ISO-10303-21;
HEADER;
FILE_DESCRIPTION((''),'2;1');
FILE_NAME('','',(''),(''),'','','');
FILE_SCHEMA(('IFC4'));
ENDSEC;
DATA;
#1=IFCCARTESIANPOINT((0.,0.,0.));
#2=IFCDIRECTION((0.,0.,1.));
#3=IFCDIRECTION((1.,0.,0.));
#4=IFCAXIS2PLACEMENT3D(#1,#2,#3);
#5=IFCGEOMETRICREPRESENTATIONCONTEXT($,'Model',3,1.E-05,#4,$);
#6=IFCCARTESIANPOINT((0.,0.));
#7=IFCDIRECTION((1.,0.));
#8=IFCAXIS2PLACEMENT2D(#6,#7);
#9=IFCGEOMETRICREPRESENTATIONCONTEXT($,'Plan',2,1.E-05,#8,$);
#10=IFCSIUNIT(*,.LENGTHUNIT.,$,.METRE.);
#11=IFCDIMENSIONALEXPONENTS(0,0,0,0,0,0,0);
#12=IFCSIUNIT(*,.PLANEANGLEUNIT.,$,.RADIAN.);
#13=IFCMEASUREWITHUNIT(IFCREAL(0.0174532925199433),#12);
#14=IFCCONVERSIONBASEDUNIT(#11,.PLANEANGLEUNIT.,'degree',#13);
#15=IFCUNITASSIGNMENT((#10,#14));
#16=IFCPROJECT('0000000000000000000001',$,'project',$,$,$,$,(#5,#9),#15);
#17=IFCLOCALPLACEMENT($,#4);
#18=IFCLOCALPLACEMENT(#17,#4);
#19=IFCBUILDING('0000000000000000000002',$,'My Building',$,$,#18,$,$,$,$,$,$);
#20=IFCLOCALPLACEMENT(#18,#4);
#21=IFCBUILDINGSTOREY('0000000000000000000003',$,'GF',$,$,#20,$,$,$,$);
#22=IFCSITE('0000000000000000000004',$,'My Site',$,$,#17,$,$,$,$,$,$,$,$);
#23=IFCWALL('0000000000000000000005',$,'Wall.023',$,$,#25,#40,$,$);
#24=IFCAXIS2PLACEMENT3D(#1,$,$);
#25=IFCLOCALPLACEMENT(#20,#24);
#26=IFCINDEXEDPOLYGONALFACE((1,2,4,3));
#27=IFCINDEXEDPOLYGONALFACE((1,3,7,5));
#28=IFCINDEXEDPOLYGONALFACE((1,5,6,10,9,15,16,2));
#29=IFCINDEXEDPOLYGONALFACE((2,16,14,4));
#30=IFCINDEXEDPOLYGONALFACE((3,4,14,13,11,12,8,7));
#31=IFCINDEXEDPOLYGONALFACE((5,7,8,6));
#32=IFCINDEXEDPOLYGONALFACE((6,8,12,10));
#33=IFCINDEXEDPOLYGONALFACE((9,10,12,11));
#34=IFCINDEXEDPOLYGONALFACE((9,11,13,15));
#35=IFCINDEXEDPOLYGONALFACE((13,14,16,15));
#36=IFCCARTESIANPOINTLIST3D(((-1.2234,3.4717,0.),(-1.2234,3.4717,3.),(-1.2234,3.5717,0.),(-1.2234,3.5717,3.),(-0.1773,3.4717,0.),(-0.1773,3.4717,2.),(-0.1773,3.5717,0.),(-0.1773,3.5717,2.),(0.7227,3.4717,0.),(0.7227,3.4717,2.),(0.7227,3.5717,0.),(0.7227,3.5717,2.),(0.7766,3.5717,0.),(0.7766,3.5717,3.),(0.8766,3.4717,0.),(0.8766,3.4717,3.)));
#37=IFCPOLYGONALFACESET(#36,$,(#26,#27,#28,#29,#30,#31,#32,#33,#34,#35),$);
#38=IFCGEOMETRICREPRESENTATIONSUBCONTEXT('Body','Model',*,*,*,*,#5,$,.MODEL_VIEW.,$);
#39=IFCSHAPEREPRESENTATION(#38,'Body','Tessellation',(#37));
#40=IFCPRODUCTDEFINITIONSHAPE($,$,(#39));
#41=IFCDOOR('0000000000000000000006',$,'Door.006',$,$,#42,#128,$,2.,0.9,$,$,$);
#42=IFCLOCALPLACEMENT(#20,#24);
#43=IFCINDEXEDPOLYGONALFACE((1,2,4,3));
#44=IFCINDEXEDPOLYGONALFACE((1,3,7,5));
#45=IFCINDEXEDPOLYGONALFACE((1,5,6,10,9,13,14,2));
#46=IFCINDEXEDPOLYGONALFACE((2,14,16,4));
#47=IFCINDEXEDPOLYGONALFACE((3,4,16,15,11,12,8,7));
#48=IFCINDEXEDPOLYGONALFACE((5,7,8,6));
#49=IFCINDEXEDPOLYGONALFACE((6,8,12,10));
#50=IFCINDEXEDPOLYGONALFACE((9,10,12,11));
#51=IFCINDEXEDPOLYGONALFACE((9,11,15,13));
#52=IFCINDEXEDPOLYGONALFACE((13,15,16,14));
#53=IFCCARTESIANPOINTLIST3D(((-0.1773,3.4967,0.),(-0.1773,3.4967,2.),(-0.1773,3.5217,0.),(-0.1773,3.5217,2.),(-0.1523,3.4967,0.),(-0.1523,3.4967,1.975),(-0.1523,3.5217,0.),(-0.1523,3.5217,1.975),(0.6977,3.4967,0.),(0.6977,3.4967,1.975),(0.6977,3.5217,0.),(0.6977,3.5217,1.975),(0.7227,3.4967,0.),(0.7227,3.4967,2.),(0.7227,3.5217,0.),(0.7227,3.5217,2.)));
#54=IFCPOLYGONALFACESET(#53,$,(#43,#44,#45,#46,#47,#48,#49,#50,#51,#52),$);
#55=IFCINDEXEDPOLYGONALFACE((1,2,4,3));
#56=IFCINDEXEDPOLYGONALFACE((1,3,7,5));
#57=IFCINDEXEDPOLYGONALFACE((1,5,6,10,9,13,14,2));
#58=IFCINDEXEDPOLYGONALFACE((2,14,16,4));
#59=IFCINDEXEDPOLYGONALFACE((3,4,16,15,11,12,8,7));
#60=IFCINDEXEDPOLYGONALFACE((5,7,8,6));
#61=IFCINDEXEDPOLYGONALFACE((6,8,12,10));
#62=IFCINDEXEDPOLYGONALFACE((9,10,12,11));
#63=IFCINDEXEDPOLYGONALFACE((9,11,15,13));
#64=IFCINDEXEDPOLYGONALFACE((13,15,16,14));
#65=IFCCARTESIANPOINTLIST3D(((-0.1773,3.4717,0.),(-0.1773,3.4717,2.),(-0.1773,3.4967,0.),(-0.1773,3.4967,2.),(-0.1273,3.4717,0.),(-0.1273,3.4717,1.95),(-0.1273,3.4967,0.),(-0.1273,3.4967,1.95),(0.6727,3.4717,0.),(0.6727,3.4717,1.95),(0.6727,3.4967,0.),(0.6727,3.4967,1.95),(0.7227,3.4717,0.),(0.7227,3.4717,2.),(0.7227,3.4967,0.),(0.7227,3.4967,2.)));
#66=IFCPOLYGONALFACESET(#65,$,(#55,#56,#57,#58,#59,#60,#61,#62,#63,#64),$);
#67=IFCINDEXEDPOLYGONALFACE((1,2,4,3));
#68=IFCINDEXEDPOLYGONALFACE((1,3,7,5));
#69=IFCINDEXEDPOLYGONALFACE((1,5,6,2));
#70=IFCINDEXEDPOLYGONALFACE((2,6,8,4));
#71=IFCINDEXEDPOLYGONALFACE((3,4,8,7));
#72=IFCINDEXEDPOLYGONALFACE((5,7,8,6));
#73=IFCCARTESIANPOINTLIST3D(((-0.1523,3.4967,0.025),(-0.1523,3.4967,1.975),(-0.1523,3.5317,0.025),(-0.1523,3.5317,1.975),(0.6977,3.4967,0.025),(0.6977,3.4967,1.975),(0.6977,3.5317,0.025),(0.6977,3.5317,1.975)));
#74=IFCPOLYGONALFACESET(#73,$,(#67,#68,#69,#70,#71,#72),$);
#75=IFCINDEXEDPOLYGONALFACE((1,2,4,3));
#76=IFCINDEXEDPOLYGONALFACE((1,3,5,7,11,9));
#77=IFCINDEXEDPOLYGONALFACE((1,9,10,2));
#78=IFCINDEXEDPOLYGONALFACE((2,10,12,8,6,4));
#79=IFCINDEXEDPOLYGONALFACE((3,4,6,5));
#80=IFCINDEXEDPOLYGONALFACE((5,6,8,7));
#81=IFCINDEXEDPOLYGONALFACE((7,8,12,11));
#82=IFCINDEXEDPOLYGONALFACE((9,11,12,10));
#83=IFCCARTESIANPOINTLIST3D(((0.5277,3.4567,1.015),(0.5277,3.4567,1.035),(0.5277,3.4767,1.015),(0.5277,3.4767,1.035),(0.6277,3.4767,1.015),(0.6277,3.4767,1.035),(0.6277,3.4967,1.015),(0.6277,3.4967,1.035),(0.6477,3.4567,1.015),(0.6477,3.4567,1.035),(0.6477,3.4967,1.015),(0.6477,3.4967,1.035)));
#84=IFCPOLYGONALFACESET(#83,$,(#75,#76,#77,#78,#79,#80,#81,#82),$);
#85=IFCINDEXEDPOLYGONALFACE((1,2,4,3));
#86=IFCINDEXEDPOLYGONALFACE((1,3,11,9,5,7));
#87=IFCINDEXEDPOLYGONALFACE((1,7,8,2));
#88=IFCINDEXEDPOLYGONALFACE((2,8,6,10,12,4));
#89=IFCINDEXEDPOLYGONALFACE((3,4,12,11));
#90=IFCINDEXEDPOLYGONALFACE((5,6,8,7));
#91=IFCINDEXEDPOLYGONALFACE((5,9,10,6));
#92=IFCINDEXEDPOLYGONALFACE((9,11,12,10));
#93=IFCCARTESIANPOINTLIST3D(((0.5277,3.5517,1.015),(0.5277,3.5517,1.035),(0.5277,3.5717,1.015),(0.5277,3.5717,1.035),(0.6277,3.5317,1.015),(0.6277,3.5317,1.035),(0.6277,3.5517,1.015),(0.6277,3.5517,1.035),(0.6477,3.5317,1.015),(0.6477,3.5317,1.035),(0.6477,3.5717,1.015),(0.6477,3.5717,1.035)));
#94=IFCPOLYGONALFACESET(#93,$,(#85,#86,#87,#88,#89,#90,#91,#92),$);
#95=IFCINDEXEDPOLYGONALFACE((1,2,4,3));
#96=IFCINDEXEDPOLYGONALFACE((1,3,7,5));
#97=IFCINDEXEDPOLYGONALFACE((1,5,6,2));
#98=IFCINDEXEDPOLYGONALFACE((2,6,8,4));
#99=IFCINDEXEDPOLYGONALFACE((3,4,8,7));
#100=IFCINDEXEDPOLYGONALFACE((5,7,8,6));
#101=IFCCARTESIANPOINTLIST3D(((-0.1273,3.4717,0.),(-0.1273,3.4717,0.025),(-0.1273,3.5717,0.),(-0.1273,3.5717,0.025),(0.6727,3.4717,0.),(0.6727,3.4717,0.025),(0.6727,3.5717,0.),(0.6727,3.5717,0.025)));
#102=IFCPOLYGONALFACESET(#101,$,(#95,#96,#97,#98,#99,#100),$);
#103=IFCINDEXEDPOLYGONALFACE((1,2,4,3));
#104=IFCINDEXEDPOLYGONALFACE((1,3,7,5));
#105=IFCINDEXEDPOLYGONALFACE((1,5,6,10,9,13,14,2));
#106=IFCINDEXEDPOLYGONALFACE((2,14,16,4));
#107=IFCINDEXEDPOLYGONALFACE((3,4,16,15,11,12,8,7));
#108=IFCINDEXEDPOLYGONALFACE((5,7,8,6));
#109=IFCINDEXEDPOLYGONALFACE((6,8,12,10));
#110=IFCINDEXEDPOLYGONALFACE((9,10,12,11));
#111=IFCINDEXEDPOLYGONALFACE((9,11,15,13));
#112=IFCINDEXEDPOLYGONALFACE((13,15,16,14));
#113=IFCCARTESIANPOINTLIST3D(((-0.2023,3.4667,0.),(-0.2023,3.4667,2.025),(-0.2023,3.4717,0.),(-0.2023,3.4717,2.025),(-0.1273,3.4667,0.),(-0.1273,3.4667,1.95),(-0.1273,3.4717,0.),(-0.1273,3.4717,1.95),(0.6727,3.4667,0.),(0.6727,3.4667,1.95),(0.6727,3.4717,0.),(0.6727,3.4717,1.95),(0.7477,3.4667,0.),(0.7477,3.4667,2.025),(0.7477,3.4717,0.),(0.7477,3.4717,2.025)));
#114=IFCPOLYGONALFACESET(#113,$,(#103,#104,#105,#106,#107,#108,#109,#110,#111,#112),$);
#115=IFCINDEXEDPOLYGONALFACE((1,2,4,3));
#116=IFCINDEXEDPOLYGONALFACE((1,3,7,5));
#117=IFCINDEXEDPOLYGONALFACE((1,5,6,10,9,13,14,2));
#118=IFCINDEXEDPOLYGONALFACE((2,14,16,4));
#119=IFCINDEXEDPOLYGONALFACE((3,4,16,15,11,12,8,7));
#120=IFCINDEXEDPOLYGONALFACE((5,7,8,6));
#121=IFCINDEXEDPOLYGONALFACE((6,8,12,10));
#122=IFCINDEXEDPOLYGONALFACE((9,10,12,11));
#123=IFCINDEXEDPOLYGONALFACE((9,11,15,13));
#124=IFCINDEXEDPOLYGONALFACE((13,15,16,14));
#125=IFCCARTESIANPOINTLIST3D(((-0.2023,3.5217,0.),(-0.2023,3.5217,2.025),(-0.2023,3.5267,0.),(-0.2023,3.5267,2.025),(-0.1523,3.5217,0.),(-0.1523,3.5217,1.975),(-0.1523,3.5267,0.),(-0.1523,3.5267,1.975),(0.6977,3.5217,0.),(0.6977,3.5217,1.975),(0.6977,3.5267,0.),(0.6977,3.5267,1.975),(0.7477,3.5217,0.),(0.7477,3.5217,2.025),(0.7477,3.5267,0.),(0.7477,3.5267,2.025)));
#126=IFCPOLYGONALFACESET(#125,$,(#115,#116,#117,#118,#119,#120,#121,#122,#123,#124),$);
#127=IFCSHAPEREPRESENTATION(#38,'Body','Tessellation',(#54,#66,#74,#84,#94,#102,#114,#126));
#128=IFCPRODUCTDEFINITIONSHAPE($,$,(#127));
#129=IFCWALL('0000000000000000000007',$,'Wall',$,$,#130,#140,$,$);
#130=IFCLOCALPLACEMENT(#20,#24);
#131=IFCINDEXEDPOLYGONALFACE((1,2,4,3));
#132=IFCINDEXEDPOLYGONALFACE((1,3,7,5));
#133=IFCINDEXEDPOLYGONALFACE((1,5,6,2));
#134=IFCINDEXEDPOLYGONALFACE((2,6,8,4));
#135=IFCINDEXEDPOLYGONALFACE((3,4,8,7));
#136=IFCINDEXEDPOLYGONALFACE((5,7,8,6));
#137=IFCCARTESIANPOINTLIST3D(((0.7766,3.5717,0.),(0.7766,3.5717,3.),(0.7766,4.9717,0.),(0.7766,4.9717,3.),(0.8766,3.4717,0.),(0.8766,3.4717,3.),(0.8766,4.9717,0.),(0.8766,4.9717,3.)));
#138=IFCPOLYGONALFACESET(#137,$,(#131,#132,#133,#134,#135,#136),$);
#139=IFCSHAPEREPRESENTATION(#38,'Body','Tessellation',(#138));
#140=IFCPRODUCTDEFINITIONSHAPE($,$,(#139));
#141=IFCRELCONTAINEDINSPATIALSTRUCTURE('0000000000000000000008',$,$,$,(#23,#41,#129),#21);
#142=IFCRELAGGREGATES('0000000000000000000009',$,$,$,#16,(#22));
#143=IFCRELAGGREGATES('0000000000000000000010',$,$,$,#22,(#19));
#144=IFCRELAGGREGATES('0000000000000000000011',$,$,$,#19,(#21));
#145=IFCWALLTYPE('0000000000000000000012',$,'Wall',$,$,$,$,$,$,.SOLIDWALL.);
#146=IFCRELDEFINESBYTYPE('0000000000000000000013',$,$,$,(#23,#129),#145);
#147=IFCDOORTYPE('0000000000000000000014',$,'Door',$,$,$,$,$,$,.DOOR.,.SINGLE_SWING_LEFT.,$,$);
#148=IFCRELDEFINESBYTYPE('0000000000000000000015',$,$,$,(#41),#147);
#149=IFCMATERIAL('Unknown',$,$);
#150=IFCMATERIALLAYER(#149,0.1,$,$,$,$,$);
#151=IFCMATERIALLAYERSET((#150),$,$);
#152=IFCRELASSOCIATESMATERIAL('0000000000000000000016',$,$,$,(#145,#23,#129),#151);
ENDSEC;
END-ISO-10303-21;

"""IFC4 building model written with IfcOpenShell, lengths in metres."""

from ifc_helpers import new_model, entity, si_unit, converted_unit, frame, origin_with_axes, origin_2d_with_axis, place, context, subcontext, project, spatial, line, indexed_curve, outline, extrude, shape, source, transform, mapped, material, layer, layer_set, layer_usage, type_object, type_shapes, element, fill, save


model = new_model("IFC4")

# Units and contexts
model_context = context("Model", 3, precision=1e-05, world=origin_with_axes())
plan_context = context("Plan", 2, precision=1e-05, world=origin_2d_with_axis())
body_context_1 = subcontext(model_context, "Body", "Model", "MODEL_VIEW")
body_context_2 = subcontext(plan_context, "Body", "Plan", "PLAN_VIEW")
ifc_project = project(units=[si_unit("LENGTHUNIT", "METRE"), converted_unit("PLANEANGLEUNIT", "degree", entity("IfcReal", 0.0174532925199433), si_unit("PLANEANGLEUNIT", "RADIAN"), dimensions=[0, 0, 0, 0, 0, 0, 0])], contexts=[model_context, plan_context])

# Site, building, storey
site_placement = place(None, origin_with_axes())
site = spatial("IfcSite", under=ifc_project, at=site_placement, Name="My Site")
building_placement = place(site_placement, origin_with_axes())
building = spatial("IfcBuilding", under=site, at=building_placement, Name="My Building")
storey_placement = place(building_placement, origin_with_axes())
storey = spatial("IfcBuildingStorey", under=building, at=storey_placement, Name="GF")

# Shared definitions
ifc_material = material(Name="Unknown")

# Shared definitions
ifc_layer_1 = layer(ifc_material, 0.1)
ifc_layer_set_1 = layer_set([ifc_layer_1])
wall_type = type_object("IfcWallType", Name="Wall", PredefinedType="SOLIDWALL", material=ifc_layer_set_1)

# Shared definitions
shared_shape_1 = source(origin_with_axes(), body_context_1, "Body", "SweptSolid", [
    extrude(outline(indexed_curve([(0.0, 0.0), (0.9, 0.0), (0.9, 2.0), (0.0, 2.0)], segments=[line(1, 2, 3, 4, 1)])), frame((0.0, -0.6, 0.0), z_axis=(0.0, -1.0, 0.0), x_axis=(1.0, 0.0, 0.0)), (0.0, 0.0, -1.0), 1.2),
])
door_type = type_object("IfcDoorType", Name="Door", OperationType="SINGLE_SWING_LEFT", PredefinedType="DOOR")
shared_shape_2 = source(origin_with_axes(), body_context_1, "Body", "SweptSolid", [
    extrude(outline(indexed_curve([(0.0, 0.0), (0.0, 2.0), (0.9, 2.0), (0.9, 0.0), (0.875, 0.0), (0.875, 1.975), (0.025, 1.975), (0.025, 0.0)], segments=[line(1, 2, 3, 4, 5, 6, 7, 8, 1)])), frame((0.0, 0.025, 0.0), z_axis=(0.0, -1.0, 0.0), x_axis=(1.0, 0.0, 0.0)), (0.0, 0.0, -1.0), 0.025),
    extrude(outline(indexed_curve([(0.0, 0.0), (0.0, 2.0), (0.9, 2.0), (0.9, 0.0), (0.85, 0.0), (0.85, 1.95), (0.05, 1.95), (0.05, 0.0)], segments=[line(1, 2, 3, 4, 5, 6, 7, 8, 1)])), frame((0.0, 0.0, 0.0), z_axis=(0.0, -1.0, 0.0), x_axis=(1.0, 0.0, 0.0)), (0.0, 0.0, -1.0), 0.025),
    extrude(outline(indexed_curve([(0.0, 0.0), (0.85, 0.0), (0.85, 0.035), (0.0, 0.035)], segments=[line(1, 2, 3, 4, 1)])), frame((0.025, 0.025, 0.025), z_axis=(0.0, 0.0, 1.0), x_axis=(1.0, 0.0, 0.0)), (0.0, 0.0, 1.0), 1.95),
    extrude(outline(indexed_curve([(0.0, 0.0), (0.0, -0.04), (-0.12, -0.04), (-0.12, -0.02), (-0.02, -0.02), (-0.02, 0.0)], segments=[line(1, 2, 3, 4, 5, 6, 1)])), frame((0.825, 0.025, 1.015), z_axis=(0.0, 0.0, 1.0), x_axis=(1.0, 0.0, 0.0)), (0.0, 0.0, 1.0), 0.02),
    extrude(outline(indexed_curve([(0.0, 0.0), (0.0, 0.04), (-0.12, 0.04), (-0.12, 0.02), (-0.02, 0.02), (-0.02, 0.0)], segments=[line(1, 2, 3, 4, 5, 6, 1)])), frame((0.825, 0.06, 1.015), z_axis=(0.0, 0.0, 1.0), x_axis=(1.0, 0.0, 0.0)), (0.0, 0.0, 1.0), 0.02),
    extrude(outline(indexed_curve([(0.0, 0.0), (0.8, 0.0), (0.8, 0.1), (0.0, 0.1)], segments=[line(1, 2, 3, 4, 1)])), frame((0.05, 0.0, 0.0), z_axis=(0.0, 0.0, 1.0), x_axis=(1.0, 0.0, 0.0)), (0.0, 0.0, 1.0), 0.025),
    extrude(outline(indexed_curve([(0.0, 0.0), (0.0, 2.025), (0.95, 2.025), (0.95, 0.0), (0.875, 0.0), (0.875, 1.95), (0.075, 1.95), (0.075, 0.0)], segments=[line(1, 2, 3, 4, 5, 6, 7, 8, 1)])), frame((-0.025, -0.005, 0.0), z_axis=(0.0, -1.0, 0.0), x_axis=(1.0, 0.0, 0.0)), (0.0, 0.0, -1.0), 0.005),
    extrude(outline(indexed_curve([(0.0, 0.0), (0.0, 2.025), (0.95, 2.025), (0.95, 0.0), (0.9, 0.0), (0.9, 1.975), (0.05, 1.975), (0.05, 0.0)], segments=[line(1, 2, 3, 4, 5, 6, 7, 8, 1)])), frame((-0.025, 0.05, 0.0), z_axis=(0.0, -1.0, 0.0), x_axis=(1.0, 0.0, 0.0)), (0.0, 0.0, -1.0), 0.005),
])
shared_shape_3 = source(origin_with_axes(), body_context_2, "Body", "Curve2D", [
    entity("IfcIndexedPolyCurve", entity("IfcCartesianPointList2D", [[0.0, 0.0], [0.0, 0.05], [0.025, 0.05], [0.025, 0.025], [0.05, 0.025], [0.05, 0.0]]), [entity("IfcLineIndex", [1, 2, 3, 4, 5, 6, 1])]),
    entity("IfcIndexedPolyCurve", entity("IfcCartesianPointList2D", [[0.9, 0.0], [0.9, 0.05], [0.875, 0.05], [0.875, 0.025], [0.85, 0.025], [0.85, 0.0]]), [entity("IfcLineIndex", [1, 2, 3, 4, 5, 6, 1])]),
    entity("IfcTrimmedCurve", entity("IfcEllipse", entity("IfcAxis2Placement2D", entity("IfcCartesianPoint", [0.06, 0.05]), entity("IfcDirection", [1.0, 0.0])), 0.815, 0.85), [entity("IfcCartesianPoint", [0.875, 0.05])], [entity("IfcCartesianPoint", [0.06, 0.9])], True, "CARTESIAN"),
    entity("IfcIndexedPolyCurve", entity("IfcCartesianPointList2D", [[0.025, 0.05], [0.06, 0.05], [0.06, 0.9], [0.025, 0.9]]), [entity("IfcLineIndex", [1, 2, 3, 4, 1])]),
])
type_shapes(door_type, [shared_shape_2, shared_shape_3])

# Wall, opening, door
ifc_layer_usage_1 = layer_usage(ifc_layer_set_1, "AXIS2", "POSITIVE", 0.0)
wall_1_placement = place(storey_placement, frame((-1.2234, 3.4717, 0.0), z_axis=(0.0, 0.0, 1.0), x_axis=(1.0, 0.0, 0.0)))
wall_1 = element("IfcWall", 1, at=wall_1_placement, inside=storey, type_object=wall_type, material=ifc_layer_usage_1, Name="Wall.023", context=body_context_1, shape_type="SweptSolid", body=[
    extrude(outline(indexed_curve([(0.0, 0.0), (0.0, 0.1), (2.0, 0.1), (2.1, 0.0)], segments=[line(1, 2, 3, 4, 1)])), origin_with_axes(), (0.0, 0.0, 1.0), 3.0),
])
opening_1_placement = place(wall_1_placement, frame((1.046, 0.0, 0.0), z_axis=(0.0, 0.0, 1.0), x_axis=(1.0, 0.0, 0.0)))
opening_1 = element("IfcOpeningElement", 2, at=opening_1_placement, cuts=wall_1, PredefinedType="OPENING", context=body_context_1, shape_type="MappedRepresentation", body=[
    mapped(shared_shape_1, transform((0.0, 0.0, 0.0), x_axis=(1.0, 0.0, 0.0), y_axis=(0.0, 1.0, 0.0), z_axis=(0.0, 0.0, 1.0), scale=1.0)),
])
door_1_placement = place(opening_1_placement, origin_with_axes())
door_1 = element("IfcDoor", 3, at=door_1_placement, inside=storey, type_object=door_type, Name="Door.006", OverallHeight=2.0, OverallWidth=0.9, shapes=[
    shape(body_context_1, "Body", "MappedRepresentation", [mapped(shared_shape_2, transform((0.0, 0.0, 0.0), x_axis=(1.0, 0.0, 0.0), y_axis=(0.0, 1.0, 0.0), z_axis=(0.0, 0.0, 1.0), scale=1.0))]),
    shape(body_context_2, "Body", "MappedRepresentation", [mapped(shared_shape_3, transform((0.0, 0.0, 0.0), x_axis=(1.0, 0.0, 0.0), y_axis=(0.0, 1.0, 0.0), z_axis=(0.0, 0.0, 1.0), scale=1.0))]),
])
fill(opening_1, door_1)

# Wall
ifc_layer_usage_2 = layer_usage(ifc_layer_set_1, "AXIS2", "POSITIVE", 0.0)
wall_2_placement = place(storey_placement, frame((0.8766, 3.4717, 0.0), z_axis=(0.0, 0.0, 1.0), x_axis=(0.0, 1.0, 0.0)))
element("IfcWall", 4, at=wall_2_placement, inside=storey, type_object=wall_type, material=ifc_layer_usage_2, Name="Wall", context=body_context_1, shape_type="SweptSolid", body=[
    extrude(outline(indexed_curve([(0.0, 0.0), (0.1, 0.1), (1.5, 0.1), (1.5, 0.0)], segments=[line(1, 2, 3, 4, 1)])), origin_with_axes(), (0.0, 0.0, 1.0), 3.0),
])

save(model, "model.ifc")
